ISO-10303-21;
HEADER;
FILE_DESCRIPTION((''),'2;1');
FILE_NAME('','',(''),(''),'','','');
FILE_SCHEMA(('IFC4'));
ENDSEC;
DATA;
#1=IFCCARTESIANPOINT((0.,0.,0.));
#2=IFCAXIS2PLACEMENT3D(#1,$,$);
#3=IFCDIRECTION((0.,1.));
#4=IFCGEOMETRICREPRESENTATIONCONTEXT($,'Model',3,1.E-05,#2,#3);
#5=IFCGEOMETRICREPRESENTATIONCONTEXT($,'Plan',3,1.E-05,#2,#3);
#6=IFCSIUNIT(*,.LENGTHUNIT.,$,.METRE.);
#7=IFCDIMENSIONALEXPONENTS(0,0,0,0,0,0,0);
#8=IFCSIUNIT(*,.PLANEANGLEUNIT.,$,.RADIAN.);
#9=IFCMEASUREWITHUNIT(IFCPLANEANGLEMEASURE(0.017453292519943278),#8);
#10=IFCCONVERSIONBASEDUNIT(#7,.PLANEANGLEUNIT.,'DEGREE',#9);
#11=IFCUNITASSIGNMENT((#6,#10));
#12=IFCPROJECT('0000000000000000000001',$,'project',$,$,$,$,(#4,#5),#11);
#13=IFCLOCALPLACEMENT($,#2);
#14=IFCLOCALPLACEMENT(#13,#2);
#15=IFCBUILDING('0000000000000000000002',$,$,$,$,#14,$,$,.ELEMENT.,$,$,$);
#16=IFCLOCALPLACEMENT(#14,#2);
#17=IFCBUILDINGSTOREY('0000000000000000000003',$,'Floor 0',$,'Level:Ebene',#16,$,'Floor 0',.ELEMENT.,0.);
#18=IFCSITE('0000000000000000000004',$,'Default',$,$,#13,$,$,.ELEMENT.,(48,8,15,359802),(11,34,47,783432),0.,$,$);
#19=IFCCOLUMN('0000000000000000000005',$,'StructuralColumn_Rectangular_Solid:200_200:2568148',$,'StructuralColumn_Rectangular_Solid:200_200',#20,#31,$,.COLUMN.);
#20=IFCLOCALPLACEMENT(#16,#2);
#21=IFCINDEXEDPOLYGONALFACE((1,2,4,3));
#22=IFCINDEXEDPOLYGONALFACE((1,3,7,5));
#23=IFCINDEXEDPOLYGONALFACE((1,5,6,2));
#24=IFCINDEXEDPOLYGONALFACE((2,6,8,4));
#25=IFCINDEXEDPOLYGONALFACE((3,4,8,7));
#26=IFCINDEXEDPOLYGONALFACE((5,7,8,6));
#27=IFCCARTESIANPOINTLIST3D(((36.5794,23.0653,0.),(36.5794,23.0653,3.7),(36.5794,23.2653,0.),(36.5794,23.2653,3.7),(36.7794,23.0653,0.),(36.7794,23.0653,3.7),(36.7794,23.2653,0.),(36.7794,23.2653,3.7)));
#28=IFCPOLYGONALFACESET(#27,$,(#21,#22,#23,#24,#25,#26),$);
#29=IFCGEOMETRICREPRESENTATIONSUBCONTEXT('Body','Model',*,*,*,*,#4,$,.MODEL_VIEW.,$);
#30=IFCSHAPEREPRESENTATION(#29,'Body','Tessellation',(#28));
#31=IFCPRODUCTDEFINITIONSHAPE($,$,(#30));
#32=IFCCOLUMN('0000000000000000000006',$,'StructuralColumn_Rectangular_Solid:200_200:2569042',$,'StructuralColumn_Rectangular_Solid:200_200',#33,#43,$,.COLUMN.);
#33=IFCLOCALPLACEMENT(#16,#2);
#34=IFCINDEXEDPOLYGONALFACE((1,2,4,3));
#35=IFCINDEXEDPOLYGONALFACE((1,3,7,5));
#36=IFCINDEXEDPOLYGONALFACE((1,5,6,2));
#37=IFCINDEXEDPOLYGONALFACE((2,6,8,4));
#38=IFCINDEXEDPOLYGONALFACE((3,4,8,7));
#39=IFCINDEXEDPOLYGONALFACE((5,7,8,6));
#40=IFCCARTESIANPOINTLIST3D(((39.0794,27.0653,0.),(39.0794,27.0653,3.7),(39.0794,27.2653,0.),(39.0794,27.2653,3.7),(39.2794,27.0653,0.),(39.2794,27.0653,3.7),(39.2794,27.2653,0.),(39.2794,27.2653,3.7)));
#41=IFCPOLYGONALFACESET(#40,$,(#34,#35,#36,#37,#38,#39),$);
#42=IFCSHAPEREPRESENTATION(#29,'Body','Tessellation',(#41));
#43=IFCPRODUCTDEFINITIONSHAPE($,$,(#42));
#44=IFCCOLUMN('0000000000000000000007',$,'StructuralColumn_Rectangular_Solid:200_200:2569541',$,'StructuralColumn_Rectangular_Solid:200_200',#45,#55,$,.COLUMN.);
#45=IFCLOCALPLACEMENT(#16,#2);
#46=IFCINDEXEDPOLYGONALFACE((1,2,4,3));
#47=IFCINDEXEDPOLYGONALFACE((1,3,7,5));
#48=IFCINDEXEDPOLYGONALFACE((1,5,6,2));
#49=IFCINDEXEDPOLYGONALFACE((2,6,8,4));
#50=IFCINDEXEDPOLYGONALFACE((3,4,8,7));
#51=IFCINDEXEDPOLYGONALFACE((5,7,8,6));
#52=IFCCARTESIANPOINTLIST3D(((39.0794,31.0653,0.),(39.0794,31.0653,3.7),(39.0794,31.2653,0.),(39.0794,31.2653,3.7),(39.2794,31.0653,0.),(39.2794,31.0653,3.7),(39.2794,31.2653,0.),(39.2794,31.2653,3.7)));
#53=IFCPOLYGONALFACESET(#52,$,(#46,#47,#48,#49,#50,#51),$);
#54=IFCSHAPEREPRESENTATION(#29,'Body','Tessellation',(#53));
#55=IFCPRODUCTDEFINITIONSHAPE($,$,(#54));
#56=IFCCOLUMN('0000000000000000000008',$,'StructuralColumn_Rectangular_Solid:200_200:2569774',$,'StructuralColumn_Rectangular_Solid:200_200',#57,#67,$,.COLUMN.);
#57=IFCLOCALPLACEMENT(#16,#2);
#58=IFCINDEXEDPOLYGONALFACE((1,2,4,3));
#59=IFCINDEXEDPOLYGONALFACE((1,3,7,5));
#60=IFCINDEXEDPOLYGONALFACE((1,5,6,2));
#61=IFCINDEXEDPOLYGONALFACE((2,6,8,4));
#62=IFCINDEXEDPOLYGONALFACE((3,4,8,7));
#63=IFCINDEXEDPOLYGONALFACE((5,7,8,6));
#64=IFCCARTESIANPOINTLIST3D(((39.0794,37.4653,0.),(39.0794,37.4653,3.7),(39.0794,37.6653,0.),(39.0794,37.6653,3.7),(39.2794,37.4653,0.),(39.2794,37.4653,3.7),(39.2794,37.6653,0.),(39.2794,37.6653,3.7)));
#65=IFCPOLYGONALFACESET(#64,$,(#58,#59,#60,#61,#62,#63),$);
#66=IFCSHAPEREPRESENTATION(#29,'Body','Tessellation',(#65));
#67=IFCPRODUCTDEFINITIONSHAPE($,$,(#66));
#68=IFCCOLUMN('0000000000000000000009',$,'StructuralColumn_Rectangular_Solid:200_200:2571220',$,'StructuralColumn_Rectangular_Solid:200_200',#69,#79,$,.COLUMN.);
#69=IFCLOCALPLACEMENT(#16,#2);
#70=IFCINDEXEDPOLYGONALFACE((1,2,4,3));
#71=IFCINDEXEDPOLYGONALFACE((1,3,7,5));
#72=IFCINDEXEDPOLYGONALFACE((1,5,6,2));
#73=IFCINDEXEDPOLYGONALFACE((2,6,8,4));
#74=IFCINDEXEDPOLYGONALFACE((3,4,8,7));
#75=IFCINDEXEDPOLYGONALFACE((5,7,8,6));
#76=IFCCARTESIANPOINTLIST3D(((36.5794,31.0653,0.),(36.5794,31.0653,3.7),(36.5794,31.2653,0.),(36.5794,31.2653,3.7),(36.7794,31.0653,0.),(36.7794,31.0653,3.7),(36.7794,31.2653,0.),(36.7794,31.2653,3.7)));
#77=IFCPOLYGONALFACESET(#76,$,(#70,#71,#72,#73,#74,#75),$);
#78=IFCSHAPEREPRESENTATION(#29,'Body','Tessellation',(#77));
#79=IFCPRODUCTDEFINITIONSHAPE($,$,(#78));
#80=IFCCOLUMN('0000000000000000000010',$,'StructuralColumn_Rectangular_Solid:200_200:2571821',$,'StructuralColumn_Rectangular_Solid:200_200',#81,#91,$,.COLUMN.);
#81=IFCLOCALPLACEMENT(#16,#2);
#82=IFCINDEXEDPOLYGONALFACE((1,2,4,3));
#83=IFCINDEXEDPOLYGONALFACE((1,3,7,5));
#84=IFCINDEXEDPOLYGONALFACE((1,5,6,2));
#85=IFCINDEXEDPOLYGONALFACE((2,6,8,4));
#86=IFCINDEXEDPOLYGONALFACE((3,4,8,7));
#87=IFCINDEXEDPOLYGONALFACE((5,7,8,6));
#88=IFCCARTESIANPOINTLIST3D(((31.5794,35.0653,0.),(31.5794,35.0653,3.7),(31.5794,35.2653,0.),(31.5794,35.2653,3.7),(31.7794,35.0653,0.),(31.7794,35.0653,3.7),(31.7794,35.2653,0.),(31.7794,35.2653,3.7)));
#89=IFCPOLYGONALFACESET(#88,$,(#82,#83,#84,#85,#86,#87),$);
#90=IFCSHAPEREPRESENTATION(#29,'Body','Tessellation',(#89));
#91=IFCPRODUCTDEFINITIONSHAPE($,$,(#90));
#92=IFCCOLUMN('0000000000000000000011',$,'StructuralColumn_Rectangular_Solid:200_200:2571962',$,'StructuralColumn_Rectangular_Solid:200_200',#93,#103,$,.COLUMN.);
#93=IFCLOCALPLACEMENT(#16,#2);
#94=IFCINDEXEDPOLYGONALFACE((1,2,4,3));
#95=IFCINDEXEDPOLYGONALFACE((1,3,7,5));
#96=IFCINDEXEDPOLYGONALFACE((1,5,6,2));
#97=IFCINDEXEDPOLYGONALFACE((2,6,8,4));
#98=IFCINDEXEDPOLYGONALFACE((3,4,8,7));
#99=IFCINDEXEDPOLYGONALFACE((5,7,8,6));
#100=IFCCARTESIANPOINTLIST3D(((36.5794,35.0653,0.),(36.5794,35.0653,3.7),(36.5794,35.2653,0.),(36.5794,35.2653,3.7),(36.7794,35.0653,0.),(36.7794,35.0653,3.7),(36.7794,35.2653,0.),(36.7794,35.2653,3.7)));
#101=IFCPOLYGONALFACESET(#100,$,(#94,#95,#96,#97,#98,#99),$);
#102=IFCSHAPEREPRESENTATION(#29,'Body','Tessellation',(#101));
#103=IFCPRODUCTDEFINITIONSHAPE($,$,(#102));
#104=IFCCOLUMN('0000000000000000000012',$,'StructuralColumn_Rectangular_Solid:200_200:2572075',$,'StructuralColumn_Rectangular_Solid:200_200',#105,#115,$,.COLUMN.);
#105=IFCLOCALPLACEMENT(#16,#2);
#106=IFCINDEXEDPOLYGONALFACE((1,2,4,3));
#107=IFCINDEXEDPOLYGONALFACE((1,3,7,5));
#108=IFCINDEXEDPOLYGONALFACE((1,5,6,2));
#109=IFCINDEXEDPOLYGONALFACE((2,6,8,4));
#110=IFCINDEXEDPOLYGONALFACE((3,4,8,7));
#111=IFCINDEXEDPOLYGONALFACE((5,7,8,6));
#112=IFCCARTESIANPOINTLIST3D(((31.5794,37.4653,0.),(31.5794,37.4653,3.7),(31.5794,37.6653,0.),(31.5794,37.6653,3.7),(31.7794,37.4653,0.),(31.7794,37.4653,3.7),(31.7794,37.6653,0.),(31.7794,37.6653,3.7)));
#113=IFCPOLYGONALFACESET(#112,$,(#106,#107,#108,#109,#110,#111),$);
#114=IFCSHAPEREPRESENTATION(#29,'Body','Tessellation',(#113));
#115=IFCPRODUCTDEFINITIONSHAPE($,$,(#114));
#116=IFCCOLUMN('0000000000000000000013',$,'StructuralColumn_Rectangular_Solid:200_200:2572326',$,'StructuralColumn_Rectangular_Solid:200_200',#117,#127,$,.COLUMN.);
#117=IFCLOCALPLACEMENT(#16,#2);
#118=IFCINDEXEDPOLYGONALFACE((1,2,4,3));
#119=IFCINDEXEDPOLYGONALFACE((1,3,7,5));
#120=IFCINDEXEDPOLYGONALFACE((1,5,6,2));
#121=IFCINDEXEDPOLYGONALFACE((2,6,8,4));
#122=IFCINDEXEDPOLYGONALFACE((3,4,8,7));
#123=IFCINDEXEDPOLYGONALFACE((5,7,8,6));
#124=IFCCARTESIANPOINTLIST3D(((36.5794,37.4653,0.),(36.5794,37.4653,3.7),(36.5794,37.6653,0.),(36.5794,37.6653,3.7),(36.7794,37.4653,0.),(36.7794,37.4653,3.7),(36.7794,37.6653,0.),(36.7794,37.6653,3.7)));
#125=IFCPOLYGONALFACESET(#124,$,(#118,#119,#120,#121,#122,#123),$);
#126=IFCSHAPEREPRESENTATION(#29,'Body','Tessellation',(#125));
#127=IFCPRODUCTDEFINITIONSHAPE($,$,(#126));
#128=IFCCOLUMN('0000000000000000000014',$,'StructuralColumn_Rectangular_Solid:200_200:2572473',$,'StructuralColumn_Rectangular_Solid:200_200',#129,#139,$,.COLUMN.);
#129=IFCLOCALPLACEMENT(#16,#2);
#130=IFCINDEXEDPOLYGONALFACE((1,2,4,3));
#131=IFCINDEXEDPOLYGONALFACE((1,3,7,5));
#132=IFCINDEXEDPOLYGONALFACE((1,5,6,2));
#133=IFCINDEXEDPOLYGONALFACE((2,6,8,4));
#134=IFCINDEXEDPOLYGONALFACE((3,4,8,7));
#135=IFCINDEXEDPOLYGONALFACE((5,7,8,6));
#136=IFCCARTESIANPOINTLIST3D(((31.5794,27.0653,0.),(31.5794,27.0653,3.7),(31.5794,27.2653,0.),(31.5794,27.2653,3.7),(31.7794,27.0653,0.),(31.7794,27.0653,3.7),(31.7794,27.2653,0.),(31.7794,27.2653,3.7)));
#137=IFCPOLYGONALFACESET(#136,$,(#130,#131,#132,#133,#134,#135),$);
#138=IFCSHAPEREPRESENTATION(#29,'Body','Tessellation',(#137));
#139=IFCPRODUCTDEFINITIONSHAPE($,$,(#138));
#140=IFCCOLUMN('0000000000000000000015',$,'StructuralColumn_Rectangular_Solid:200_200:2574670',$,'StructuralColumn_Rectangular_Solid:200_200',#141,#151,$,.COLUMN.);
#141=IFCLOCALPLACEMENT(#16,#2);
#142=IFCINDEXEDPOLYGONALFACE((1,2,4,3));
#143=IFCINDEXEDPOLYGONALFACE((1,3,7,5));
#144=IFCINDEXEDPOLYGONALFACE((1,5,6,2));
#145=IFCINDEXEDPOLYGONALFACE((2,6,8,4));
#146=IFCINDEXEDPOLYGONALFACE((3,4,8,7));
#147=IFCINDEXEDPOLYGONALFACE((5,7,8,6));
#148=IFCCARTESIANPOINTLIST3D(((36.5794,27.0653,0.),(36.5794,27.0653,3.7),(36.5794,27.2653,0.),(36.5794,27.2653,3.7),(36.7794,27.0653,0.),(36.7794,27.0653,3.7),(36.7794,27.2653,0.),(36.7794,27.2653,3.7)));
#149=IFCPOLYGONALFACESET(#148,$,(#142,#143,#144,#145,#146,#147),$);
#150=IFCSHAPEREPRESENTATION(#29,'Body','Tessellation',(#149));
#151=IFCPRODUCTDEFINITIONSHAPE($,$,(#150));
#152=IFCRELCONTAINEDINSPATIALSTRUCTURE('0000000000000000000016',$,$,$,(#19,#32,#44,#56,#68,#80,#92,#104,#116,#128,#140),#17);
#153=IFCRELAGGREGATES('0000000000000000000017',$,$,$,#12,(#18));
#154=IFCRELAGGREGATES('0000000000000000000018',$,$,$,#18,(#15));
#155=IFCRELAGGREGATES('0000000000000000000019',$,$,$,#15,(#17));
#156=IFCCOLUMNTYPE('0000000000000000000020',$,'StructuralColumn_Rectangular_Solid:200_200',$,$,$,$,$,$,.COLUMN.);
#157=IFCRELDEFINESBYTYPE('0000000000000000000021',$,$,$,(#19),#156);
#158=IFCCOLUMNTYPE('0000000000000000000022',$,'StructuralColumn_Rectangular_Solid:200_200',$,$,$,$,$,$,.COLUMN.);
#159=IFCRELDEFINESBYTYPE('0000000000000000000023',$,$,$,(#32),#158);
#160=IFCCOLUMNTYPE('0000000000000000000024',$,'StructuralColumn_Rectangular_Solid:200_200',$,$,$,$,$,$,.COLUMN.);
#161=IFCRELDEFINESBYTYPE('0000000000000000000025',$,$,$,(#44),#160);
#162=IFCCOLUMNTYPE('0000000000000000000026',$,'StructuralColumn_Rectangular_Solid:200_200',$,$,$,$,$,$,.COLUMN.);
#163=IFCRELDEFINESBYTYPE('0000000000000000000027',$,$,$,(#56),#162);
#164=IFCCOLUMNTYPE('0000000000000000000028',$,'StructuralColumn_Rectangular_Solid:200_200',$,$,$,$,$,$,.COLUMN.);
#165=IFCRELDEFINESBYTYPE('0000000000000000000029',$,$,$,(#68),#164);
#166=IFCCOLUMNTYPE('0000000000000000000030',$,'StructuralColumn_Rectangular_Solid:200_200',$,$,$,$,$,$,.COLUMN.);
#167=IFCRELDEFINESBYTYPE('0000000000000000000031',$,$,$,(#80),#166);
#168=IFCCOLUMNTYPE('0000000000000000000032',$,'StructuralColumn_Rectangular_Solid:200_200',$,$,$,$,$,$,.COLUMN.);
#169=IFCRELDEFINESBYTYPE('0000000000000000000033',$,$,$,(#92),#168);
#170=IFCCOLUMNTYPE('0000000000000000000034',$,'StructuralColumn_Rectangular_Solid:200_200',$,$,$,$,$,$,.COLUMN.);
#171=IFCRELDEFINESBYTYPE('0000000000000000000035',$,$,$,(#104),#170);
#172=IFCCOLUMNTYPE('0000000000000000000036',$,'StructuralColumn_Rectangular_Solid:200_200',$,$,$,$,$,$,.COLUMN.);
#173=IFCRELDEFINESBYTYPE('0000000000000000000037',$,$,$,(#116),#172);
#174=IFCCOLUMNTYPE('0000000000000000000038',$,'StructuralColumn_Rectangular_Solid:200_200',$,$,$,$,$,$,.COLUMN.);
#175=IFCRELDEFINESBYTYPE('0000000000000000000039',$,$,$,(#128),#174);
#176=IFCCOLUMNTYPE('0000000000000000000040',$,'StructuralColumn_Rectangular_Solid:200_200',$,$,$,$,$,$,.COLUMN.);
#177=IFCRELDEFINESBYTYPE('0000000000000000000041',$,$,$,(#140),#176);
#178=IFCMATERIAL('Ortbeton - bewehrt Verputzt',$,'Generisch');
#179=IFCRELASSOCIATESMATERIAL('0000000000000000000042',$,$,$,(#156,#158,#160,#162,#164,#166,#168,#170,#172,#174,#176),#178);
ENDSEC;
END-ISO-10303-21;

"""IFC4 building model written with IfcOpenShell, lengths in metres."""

from ifc_helpers import new_model, entity, si_unit, converted_unit, direction, frame, frame_2d, origin, origin_2d_with_axis, place, context, subcontext, project, spatial, rectangle, extrude, source, transform, mapped, material, material_profile, profile_set, type_object, type_shapes, element, save


model = new_model("IFC4")

# Units and contexts
model_context = context("Model", 3, precision=1e-05, world=origin(), true_north=direction((0.0, 1.0)))
plan_context = context("Plan", 3, precision=1e-05, world=origin(), true_north=direction((0.0, 1.0)))
body_context = subcontext(model_context, "Body", "Model", "MODEL_VIEW")
ifc_project = project(units=[si_unit("LENGTHUNIT", "METRE"), converted_unit("PLANEANGLEUNIT", "DEGREE", entity("IfcPlaneAngleMeasure", 0.017453292519943278), si_unit("PLANEANGLEUNIT", "RADIAN"), dimensions=[0, 0, 0, 0, 0, 0, 0])], contexts=[model_context, plan_context])

# Site, building, storey
site_placement = place(None, origin())
site = spatial("IfcSite", under=ifc_project, at=site_placement, Name="Default", CompositionType="ELEMENT", RefLatitude=(48, 8, 15, 359802), RefLongitude=(11, 34, 47, 783432), RefElevation=0.0)
building_placement = place(site_placement, origin())
building = spatial("IfcBuilding", under=site, at=building_placement, CompositionType="ELEMENT")
storey_placement = place(building_placement, origin())
storey = spatial("IfcBuildingStorey", under=building, at=storey_placement, Name="Floor 0", ObjectType="Level:Ebene", LongName="Floor 0", CompositionType="ELEMENT", Elevation=0.0)

# Columns
ifc_material_1 = material(Name="Ortbeton - bewehrt Verputzt", Category="Generisch")
ifc_material_profile = material_profile(ifc_material_1, rectangle(XDim=0.2, YDim=0.2, at=frame_2d((0.0, 0.0), x_axis=(1.0, 0.0))), Name="200_200")
ifc_profile_set = profile_set([ifc_material_profile], Name="200_200")
column_type_1 = type_object("IfcColumnType", Name="StructuralColumn_Rectangular_Solid:200_200", PredefinedType="COLUMN", material=ifc_profile_set)
shared_shape_1 = source(origin(), body_context, "Body", "SweptSolid", [
    extrude(rectangle(XDim=0.2, YDim=0.2, at=origin_2d_with_axis()), frame((36.6794, 23.1653, 0.0), z_axis=(0.0, 0.0, 1.0), x_axis=(-1.0, 0.0, 0.0)), (0.0, 0.0, 1.0), 3.7),
])
type_shapes(column_type_1, [shared_shape_1])
column_1_placement = place(storey_placement, origin())
element("IfcColumn", 1, at=column_1_placement, inside=storey, type_object=column_type_1, Name="StructuralColumn_Rectangular_Solid:200_200:2568148", ObjectType="StructuralColumn_Rectangular_Solid:200_200", PredefinedType="COLUMN", context=body_context, shape_type="MappedRepresentation", body=[
    mapped(shared_shape_1, transform((0.0, 0.0, 0.0), scale=1.0)),
])
column_type_2 = type_object("IfcColumnType", Name="StructuralColumn_Rectangular_Solid:200_200", PredefinedType="COLUMN", material=ifc_profile_set)
shared_shape_2 = source(origin(), body_context, "Body", "SweptSolid", [
    extrude(rectangle(XDim=0.2, YDim=0.2, at=frame_2d((0.0, 0.0), x_axis=(1.0, 0.0))), frame((39.1794, 27.1653, 0.0), z_axis=(0.0, 0.0, 1.0), x_axis=(-1.0, 0.0, 0.0)), (0.0, 0.0, 1.0), 3.7),
])
type_shapes(column_type_2, [shared_shape_2])
column_2_placement = place(storey_placement, origin())
element("IfcColumn", 2, at=column_2_placement, inside=storey, type_object=column_type_2, Name="StructuralColumn_Rectangular_Solid:200_200:2569042", ObjectType="StructuralColumn_Rectangular_Solid:200_200", PredefinedType="COLUMN", context=body_context, shape_type="MappedRepresentation", body=[
    mapped(shared_shape_2, transform((0.0, 0.0, 0.0), scale=1.0)),
])
column_type_3 = type_object("IfcColumnType", Name="StructuralColumn_Rectangular_Solid:200_200", PredefinedType="COLUMN", material=ifc_profile_set)
shared_shape_3 = source(origin(), body_context, "Body", "SweptSolid", [
    extrude(rectangle(XDim=0.2, YDim=0.2, at=frame_2d((0.0, 0.0), x_axis=(1.0, 0.0))), frame((39.1794, 31.1653, 0.0), z_axis=(0.0, 0.0, 1.0), x_axis=(-1.0, 0.0, 0.0)), (0.0, 0.0, 1.0), 3.7),
])
type_shapes(column_type_3, [shared_shape_3])
column_3_placement = place(storey_placement, origin())
element("IfcColumn", 3, at=column_3_placement, inside=storey, type_object=column_type_3, Name="StructuralColumn_Rectangular_Solid:200_200:2569541", ObjectType="StructuralColumn_Rectangular_Solid:200_200", PredefinedType="COLUMN", context=body_context, shape_type="MappedRepresentation", body=[
    mapped(shared_shape_3, transform((0.0, 0.0, 0.0), scale=1.0)),
])
column_type_4 = type_object("IfcColumnType", Name="StructuralColumn_Rectangular_Solid:200_200", PredefinedType="COLUMN", material=ifc_profile_set)
shared_shape_4 = source(origin(), body_context, "Body", "SweptSolid", [
    extrude(rectangle(XDim=0.2, YDim=0.2, at=frame_2d((0.0, 0.0), x_axis=(1.0, 0.0))), frame((39.1794, 37.5653, 0.0), z_axis=(0.0, 0.0, 1.0), x_axis=(-1.0, 0.0, 0.0)), (0.0, 0.0, 1.0), 3.7),
])
type_shapes(column_type_4, [shared_shape_4])
column_4_placement = place(storey_placement, origin())
element("IfcColumn", 4, at=column_4_placement, inside=storey, type_object=column_type_4, Name="StructuralColumn_Rectangular_Solid:200_200:2569774", ObjectType="StructuralColumn_Rectangular_Solid:200_200", PredefinedType="COLUMN", context=body_context, shape_type="MappedRepresentation", body=[
    mapped(shared_shape_4, transform((0.0, 0.0, 0.0), scale=1.0)),
])
column_type_5 = type_object("IfcColumnType", Name="StructuralColumn_Rectangular_Solid:200_200", PredefinedType="COLUMN", material=ifc_profile_set)
shared_shape_5 = source(origin(), body_context, "Body", "SweptSolid", [
    extrude(rectangle(XDim=0.2, YDim=0.2, at=frame_2d((0.0, 0.0), x_axis=(1.0, 0.0))), frame((36.6794, 31.1653, 0.0), z_axis=(0.0, 0.0, 1.0), x_axis=(-1.0, 0.0, 0.0)), (0.0, 0.0, 1.0), 3.7),
])
type_shapes(column_type_5, [shared_shape_5])
column_5_placement = place(storey_placement, origin())
element("IfcColumn", 5, at=column_5_placement, inside=storey, type_object=column_type_5, Name="StructuralColumn_Rectangular_Solid:200_200:2571220", ObjectType="StructuralColumn_Rectangular_Solid:200_200", PredefinedType="COLUMN", context=body_context, shape_type="MappedRepresentation", body=[
    mapped(shared_shape_5, transform((0.0, 0.0, 0.0), scale=1.0)),
])
column_type_6 = type_object("IfcColumnType", Name="StructuralColumn_Rectangular_Solid:200_200", PredefinedType="COLUMN", material=ifc_profile_set)
shared_shape_6 = source(origin(), body_context, "Body", "SweptSolid", [
    extrude(rectangle(XDim=0.2, YDim=0.2, at=origin_2d_with_axis()), frame((31.6794, 35.1653, 0.0), z_axis=(0.0, 0.0, 1.0), x_axis=(-1.0, 0.0, 0.0)), (0.0, 0.0, 1.0), 3.7),
])
type_shapes(column_type_6, [shared_shape_6])
column_6_placement = place(storey_placement, origin())
element("IfcColumn", 6, at=column_6_placement, inside=storey, type_object=column_type_6, Name="StructuralColumn_Rectangular_Solid:200_200:2571821", ObjectType="StructuralColumn_Rectangular_Solid:200_200", PredefinedType="COLUMN", context=body_context, shape_type="MappedRepresentation", body=[
    mapped(shared_shape_6, transform((0.0, 0.0, 0.0), scale=1.0)),
])
column_type_7 = type_object("IfcColumnType", Name="StructuralColumn_Rectangular_Solid:200_200", PredefinedType="COLUMN", material=ifc_profile_set)
shared_shape_7 = source(origin(), body_context, "Body", "SweptSolid", [
    extrude(rectangle(XDim=0.2, YDim=0.2, at=origin_2d_with_axis()), frame((36.6794, 35.1653, 0.0), z_axis=(0.0, 0.0, 1.0), x_axis=(-1.0, 0.0, 0.0)), (0.0, 0.0, 1.0), 3.7),
])
type_shapes(column_type_7, [shared_shape_7])
column_7_placement = place(storey_placement, origin())
element("IfcColumn", 7, at=column_7_placement, inside=storey, type_object=column_type_7, Name="StructuralColumn_Rectangular_Solid:200_200:2571962", ObjectType="StructuralColumn_Rectangular_Solid:200_200", PredefinedType="COLUMN", context=body_context, shape_type="MappedRepresentation", body=[
    mapped(shared_shape_7, transform((0.0, 0.0, 0.0), scale=1.0)),
])
column_type_8 = type_object("IfcColumnType", Name="StructuralColumn_Rectangular_Solid:200_200", PredefinedType="COLUMN", material=ifc_profile_set)
shared_shape_8 = source(origin(), body_context, "Body", "SweptSolid", [
    extrude(rectangle(XDim=0.2, YDim=0.2, at=frame_2d((0.0, 0.0), x_axis=(1.0, 0.0))), frame((31.6794, 37.5653, 0.0), z_axis=(0.0, 0.0, 1.0), x_axis=(-1.0, 0.0, 0.0)), (0.0, 0.0, 1.0), 3.7),
])
type_shapes(column_type_8, [shared_shape_8])
column_8_placement = place(storey_placement, origin())
element("IfcColumn", 8, at=column_8_placement, inside=storey, type_object=column_type_8, Name="StructuralColumn_Rectangular_Solid:200_200:2572075", ObjectType="StructuralColumn_Rectangular_Solid:200_200", PredefinedType="COLUMN", context=body_context, shape_type="MappedRepresentation", body=[
    mapped(shared_shape_8, transform((0.0, 0.0, 0.0), scale=1.0)),
])
column_type_9 = type_object("IfcColumnType", Name="StructuralColumn_Rectangular_Solid:200_200", PredefinedType="COLUMN", material=ifc_profile_set)
shared_shape_9 = source(origin(), body_context, "Body", "SweptSolid", [
    extrude(rectangle(XDim=0.2, YDim=0.2, at=origin_2d_with_axis()), frame((36.6794, 37.5653, 0.0), z_axis=(0.0, 0.0, 1.0), x_axis=(-1.0, 0.0, 0.0)), (0.0, 0.0, 1.0), 3.7),
])
type_shapes(column_type_9, [shared_shape_9])
column_9_placement = place(storey_placement, origin())
element("IfcColumn", 9, at=column_9_placement, inside=storey, type_object=column_type_9, Name="StructuralColumn_Rectangular_Solid:200_200:2572326", ObjectType="StructuralColumn_Rectangular_Solid:200_200", PredefinedType="COLUMN", context=body_context, shape_type="MappedRepresentation", body=[
    mapped(shared_shape_9, transform((0.0, 0.0, 0.0), scale=1.0)),
])
column_type_10 = type_object("IfcColumnType", Name="StructuralColumn_Rectangular_Solid:200_200", PredefinedType="COLUMN", material=ifc_profile_set)
shared_shape_10 = source(origin(), body_context, "Body", "SweptSolid", [
    extrude(rectangle(XDim=0.2, YDim=0.2, at=frame_2d((0.0, 0.0), x_axis=(1.0, 0.0))), frame((31.6794, 27.1653, 0.0), z_axis=(0.0, 0.0, 1.0), x_axis=(-1.0, 0.0, 0.0)), (0.0, 0.0, 1.0), 3.7),
])
type_shapes(column_type_10, [shared_shape_10])
column_10_placement = place(storey_placement, origin())
element("IfcColumn", 10, at=column_10_placement, inside=storey, type_object=column_type_10, Name="StructuralColumn_Rectangular_Solid:200_200:2572473", ObjectType="StructuralColumn_Rectangular_Solid:200_200", PredefinedType="COLUMN", context=body_context, shape_type="MappedRepresentation", body=[
    mapped(shared_shape_10, transform((0.0, 0.0, 0.0), scale=1.0)),
])
column_type_11 = type_object("IfcColumnType", Name="StructuralColumn_Rectangular_Solid:200_200", PredefinedType="COLUMN", material=ifc_profile_set)
shared_shape_11 = source(origin(), body_context, "Body", "SweptSolid", [
    extrude(rectangle(XDim=0.2, YDim=0.2, at=origin_2d_with_axis()), frame((36.6794, 27.1653, 0.0), z_axis=(0.0, 0.0, 1.0), x_axis=(-1.0, 0.0, 0.0)), (0.0, 0.0, 1.0), 3.7),
])
type_shapes(column_type_11, [shared_shape_11])
column_11_placement = place(storey_placement, origin())
element("IfcColumn", 11, at=column_11_placement, inside=storey, type_object=column_type_11, Name="StructuralColumn_Rectangular_Solid:200_200:2574670", ObjectType="StructuralColumn_Rectangular_Solid:200_200", PredefinedType="COLUMN", context=body_context, shape_type="MappedRepresentation", body=[
    mapped(shared_shape_11, transform((0.0, 0.0, 0.0), scale=1.0)),
])

save(model, "model.ifc")
